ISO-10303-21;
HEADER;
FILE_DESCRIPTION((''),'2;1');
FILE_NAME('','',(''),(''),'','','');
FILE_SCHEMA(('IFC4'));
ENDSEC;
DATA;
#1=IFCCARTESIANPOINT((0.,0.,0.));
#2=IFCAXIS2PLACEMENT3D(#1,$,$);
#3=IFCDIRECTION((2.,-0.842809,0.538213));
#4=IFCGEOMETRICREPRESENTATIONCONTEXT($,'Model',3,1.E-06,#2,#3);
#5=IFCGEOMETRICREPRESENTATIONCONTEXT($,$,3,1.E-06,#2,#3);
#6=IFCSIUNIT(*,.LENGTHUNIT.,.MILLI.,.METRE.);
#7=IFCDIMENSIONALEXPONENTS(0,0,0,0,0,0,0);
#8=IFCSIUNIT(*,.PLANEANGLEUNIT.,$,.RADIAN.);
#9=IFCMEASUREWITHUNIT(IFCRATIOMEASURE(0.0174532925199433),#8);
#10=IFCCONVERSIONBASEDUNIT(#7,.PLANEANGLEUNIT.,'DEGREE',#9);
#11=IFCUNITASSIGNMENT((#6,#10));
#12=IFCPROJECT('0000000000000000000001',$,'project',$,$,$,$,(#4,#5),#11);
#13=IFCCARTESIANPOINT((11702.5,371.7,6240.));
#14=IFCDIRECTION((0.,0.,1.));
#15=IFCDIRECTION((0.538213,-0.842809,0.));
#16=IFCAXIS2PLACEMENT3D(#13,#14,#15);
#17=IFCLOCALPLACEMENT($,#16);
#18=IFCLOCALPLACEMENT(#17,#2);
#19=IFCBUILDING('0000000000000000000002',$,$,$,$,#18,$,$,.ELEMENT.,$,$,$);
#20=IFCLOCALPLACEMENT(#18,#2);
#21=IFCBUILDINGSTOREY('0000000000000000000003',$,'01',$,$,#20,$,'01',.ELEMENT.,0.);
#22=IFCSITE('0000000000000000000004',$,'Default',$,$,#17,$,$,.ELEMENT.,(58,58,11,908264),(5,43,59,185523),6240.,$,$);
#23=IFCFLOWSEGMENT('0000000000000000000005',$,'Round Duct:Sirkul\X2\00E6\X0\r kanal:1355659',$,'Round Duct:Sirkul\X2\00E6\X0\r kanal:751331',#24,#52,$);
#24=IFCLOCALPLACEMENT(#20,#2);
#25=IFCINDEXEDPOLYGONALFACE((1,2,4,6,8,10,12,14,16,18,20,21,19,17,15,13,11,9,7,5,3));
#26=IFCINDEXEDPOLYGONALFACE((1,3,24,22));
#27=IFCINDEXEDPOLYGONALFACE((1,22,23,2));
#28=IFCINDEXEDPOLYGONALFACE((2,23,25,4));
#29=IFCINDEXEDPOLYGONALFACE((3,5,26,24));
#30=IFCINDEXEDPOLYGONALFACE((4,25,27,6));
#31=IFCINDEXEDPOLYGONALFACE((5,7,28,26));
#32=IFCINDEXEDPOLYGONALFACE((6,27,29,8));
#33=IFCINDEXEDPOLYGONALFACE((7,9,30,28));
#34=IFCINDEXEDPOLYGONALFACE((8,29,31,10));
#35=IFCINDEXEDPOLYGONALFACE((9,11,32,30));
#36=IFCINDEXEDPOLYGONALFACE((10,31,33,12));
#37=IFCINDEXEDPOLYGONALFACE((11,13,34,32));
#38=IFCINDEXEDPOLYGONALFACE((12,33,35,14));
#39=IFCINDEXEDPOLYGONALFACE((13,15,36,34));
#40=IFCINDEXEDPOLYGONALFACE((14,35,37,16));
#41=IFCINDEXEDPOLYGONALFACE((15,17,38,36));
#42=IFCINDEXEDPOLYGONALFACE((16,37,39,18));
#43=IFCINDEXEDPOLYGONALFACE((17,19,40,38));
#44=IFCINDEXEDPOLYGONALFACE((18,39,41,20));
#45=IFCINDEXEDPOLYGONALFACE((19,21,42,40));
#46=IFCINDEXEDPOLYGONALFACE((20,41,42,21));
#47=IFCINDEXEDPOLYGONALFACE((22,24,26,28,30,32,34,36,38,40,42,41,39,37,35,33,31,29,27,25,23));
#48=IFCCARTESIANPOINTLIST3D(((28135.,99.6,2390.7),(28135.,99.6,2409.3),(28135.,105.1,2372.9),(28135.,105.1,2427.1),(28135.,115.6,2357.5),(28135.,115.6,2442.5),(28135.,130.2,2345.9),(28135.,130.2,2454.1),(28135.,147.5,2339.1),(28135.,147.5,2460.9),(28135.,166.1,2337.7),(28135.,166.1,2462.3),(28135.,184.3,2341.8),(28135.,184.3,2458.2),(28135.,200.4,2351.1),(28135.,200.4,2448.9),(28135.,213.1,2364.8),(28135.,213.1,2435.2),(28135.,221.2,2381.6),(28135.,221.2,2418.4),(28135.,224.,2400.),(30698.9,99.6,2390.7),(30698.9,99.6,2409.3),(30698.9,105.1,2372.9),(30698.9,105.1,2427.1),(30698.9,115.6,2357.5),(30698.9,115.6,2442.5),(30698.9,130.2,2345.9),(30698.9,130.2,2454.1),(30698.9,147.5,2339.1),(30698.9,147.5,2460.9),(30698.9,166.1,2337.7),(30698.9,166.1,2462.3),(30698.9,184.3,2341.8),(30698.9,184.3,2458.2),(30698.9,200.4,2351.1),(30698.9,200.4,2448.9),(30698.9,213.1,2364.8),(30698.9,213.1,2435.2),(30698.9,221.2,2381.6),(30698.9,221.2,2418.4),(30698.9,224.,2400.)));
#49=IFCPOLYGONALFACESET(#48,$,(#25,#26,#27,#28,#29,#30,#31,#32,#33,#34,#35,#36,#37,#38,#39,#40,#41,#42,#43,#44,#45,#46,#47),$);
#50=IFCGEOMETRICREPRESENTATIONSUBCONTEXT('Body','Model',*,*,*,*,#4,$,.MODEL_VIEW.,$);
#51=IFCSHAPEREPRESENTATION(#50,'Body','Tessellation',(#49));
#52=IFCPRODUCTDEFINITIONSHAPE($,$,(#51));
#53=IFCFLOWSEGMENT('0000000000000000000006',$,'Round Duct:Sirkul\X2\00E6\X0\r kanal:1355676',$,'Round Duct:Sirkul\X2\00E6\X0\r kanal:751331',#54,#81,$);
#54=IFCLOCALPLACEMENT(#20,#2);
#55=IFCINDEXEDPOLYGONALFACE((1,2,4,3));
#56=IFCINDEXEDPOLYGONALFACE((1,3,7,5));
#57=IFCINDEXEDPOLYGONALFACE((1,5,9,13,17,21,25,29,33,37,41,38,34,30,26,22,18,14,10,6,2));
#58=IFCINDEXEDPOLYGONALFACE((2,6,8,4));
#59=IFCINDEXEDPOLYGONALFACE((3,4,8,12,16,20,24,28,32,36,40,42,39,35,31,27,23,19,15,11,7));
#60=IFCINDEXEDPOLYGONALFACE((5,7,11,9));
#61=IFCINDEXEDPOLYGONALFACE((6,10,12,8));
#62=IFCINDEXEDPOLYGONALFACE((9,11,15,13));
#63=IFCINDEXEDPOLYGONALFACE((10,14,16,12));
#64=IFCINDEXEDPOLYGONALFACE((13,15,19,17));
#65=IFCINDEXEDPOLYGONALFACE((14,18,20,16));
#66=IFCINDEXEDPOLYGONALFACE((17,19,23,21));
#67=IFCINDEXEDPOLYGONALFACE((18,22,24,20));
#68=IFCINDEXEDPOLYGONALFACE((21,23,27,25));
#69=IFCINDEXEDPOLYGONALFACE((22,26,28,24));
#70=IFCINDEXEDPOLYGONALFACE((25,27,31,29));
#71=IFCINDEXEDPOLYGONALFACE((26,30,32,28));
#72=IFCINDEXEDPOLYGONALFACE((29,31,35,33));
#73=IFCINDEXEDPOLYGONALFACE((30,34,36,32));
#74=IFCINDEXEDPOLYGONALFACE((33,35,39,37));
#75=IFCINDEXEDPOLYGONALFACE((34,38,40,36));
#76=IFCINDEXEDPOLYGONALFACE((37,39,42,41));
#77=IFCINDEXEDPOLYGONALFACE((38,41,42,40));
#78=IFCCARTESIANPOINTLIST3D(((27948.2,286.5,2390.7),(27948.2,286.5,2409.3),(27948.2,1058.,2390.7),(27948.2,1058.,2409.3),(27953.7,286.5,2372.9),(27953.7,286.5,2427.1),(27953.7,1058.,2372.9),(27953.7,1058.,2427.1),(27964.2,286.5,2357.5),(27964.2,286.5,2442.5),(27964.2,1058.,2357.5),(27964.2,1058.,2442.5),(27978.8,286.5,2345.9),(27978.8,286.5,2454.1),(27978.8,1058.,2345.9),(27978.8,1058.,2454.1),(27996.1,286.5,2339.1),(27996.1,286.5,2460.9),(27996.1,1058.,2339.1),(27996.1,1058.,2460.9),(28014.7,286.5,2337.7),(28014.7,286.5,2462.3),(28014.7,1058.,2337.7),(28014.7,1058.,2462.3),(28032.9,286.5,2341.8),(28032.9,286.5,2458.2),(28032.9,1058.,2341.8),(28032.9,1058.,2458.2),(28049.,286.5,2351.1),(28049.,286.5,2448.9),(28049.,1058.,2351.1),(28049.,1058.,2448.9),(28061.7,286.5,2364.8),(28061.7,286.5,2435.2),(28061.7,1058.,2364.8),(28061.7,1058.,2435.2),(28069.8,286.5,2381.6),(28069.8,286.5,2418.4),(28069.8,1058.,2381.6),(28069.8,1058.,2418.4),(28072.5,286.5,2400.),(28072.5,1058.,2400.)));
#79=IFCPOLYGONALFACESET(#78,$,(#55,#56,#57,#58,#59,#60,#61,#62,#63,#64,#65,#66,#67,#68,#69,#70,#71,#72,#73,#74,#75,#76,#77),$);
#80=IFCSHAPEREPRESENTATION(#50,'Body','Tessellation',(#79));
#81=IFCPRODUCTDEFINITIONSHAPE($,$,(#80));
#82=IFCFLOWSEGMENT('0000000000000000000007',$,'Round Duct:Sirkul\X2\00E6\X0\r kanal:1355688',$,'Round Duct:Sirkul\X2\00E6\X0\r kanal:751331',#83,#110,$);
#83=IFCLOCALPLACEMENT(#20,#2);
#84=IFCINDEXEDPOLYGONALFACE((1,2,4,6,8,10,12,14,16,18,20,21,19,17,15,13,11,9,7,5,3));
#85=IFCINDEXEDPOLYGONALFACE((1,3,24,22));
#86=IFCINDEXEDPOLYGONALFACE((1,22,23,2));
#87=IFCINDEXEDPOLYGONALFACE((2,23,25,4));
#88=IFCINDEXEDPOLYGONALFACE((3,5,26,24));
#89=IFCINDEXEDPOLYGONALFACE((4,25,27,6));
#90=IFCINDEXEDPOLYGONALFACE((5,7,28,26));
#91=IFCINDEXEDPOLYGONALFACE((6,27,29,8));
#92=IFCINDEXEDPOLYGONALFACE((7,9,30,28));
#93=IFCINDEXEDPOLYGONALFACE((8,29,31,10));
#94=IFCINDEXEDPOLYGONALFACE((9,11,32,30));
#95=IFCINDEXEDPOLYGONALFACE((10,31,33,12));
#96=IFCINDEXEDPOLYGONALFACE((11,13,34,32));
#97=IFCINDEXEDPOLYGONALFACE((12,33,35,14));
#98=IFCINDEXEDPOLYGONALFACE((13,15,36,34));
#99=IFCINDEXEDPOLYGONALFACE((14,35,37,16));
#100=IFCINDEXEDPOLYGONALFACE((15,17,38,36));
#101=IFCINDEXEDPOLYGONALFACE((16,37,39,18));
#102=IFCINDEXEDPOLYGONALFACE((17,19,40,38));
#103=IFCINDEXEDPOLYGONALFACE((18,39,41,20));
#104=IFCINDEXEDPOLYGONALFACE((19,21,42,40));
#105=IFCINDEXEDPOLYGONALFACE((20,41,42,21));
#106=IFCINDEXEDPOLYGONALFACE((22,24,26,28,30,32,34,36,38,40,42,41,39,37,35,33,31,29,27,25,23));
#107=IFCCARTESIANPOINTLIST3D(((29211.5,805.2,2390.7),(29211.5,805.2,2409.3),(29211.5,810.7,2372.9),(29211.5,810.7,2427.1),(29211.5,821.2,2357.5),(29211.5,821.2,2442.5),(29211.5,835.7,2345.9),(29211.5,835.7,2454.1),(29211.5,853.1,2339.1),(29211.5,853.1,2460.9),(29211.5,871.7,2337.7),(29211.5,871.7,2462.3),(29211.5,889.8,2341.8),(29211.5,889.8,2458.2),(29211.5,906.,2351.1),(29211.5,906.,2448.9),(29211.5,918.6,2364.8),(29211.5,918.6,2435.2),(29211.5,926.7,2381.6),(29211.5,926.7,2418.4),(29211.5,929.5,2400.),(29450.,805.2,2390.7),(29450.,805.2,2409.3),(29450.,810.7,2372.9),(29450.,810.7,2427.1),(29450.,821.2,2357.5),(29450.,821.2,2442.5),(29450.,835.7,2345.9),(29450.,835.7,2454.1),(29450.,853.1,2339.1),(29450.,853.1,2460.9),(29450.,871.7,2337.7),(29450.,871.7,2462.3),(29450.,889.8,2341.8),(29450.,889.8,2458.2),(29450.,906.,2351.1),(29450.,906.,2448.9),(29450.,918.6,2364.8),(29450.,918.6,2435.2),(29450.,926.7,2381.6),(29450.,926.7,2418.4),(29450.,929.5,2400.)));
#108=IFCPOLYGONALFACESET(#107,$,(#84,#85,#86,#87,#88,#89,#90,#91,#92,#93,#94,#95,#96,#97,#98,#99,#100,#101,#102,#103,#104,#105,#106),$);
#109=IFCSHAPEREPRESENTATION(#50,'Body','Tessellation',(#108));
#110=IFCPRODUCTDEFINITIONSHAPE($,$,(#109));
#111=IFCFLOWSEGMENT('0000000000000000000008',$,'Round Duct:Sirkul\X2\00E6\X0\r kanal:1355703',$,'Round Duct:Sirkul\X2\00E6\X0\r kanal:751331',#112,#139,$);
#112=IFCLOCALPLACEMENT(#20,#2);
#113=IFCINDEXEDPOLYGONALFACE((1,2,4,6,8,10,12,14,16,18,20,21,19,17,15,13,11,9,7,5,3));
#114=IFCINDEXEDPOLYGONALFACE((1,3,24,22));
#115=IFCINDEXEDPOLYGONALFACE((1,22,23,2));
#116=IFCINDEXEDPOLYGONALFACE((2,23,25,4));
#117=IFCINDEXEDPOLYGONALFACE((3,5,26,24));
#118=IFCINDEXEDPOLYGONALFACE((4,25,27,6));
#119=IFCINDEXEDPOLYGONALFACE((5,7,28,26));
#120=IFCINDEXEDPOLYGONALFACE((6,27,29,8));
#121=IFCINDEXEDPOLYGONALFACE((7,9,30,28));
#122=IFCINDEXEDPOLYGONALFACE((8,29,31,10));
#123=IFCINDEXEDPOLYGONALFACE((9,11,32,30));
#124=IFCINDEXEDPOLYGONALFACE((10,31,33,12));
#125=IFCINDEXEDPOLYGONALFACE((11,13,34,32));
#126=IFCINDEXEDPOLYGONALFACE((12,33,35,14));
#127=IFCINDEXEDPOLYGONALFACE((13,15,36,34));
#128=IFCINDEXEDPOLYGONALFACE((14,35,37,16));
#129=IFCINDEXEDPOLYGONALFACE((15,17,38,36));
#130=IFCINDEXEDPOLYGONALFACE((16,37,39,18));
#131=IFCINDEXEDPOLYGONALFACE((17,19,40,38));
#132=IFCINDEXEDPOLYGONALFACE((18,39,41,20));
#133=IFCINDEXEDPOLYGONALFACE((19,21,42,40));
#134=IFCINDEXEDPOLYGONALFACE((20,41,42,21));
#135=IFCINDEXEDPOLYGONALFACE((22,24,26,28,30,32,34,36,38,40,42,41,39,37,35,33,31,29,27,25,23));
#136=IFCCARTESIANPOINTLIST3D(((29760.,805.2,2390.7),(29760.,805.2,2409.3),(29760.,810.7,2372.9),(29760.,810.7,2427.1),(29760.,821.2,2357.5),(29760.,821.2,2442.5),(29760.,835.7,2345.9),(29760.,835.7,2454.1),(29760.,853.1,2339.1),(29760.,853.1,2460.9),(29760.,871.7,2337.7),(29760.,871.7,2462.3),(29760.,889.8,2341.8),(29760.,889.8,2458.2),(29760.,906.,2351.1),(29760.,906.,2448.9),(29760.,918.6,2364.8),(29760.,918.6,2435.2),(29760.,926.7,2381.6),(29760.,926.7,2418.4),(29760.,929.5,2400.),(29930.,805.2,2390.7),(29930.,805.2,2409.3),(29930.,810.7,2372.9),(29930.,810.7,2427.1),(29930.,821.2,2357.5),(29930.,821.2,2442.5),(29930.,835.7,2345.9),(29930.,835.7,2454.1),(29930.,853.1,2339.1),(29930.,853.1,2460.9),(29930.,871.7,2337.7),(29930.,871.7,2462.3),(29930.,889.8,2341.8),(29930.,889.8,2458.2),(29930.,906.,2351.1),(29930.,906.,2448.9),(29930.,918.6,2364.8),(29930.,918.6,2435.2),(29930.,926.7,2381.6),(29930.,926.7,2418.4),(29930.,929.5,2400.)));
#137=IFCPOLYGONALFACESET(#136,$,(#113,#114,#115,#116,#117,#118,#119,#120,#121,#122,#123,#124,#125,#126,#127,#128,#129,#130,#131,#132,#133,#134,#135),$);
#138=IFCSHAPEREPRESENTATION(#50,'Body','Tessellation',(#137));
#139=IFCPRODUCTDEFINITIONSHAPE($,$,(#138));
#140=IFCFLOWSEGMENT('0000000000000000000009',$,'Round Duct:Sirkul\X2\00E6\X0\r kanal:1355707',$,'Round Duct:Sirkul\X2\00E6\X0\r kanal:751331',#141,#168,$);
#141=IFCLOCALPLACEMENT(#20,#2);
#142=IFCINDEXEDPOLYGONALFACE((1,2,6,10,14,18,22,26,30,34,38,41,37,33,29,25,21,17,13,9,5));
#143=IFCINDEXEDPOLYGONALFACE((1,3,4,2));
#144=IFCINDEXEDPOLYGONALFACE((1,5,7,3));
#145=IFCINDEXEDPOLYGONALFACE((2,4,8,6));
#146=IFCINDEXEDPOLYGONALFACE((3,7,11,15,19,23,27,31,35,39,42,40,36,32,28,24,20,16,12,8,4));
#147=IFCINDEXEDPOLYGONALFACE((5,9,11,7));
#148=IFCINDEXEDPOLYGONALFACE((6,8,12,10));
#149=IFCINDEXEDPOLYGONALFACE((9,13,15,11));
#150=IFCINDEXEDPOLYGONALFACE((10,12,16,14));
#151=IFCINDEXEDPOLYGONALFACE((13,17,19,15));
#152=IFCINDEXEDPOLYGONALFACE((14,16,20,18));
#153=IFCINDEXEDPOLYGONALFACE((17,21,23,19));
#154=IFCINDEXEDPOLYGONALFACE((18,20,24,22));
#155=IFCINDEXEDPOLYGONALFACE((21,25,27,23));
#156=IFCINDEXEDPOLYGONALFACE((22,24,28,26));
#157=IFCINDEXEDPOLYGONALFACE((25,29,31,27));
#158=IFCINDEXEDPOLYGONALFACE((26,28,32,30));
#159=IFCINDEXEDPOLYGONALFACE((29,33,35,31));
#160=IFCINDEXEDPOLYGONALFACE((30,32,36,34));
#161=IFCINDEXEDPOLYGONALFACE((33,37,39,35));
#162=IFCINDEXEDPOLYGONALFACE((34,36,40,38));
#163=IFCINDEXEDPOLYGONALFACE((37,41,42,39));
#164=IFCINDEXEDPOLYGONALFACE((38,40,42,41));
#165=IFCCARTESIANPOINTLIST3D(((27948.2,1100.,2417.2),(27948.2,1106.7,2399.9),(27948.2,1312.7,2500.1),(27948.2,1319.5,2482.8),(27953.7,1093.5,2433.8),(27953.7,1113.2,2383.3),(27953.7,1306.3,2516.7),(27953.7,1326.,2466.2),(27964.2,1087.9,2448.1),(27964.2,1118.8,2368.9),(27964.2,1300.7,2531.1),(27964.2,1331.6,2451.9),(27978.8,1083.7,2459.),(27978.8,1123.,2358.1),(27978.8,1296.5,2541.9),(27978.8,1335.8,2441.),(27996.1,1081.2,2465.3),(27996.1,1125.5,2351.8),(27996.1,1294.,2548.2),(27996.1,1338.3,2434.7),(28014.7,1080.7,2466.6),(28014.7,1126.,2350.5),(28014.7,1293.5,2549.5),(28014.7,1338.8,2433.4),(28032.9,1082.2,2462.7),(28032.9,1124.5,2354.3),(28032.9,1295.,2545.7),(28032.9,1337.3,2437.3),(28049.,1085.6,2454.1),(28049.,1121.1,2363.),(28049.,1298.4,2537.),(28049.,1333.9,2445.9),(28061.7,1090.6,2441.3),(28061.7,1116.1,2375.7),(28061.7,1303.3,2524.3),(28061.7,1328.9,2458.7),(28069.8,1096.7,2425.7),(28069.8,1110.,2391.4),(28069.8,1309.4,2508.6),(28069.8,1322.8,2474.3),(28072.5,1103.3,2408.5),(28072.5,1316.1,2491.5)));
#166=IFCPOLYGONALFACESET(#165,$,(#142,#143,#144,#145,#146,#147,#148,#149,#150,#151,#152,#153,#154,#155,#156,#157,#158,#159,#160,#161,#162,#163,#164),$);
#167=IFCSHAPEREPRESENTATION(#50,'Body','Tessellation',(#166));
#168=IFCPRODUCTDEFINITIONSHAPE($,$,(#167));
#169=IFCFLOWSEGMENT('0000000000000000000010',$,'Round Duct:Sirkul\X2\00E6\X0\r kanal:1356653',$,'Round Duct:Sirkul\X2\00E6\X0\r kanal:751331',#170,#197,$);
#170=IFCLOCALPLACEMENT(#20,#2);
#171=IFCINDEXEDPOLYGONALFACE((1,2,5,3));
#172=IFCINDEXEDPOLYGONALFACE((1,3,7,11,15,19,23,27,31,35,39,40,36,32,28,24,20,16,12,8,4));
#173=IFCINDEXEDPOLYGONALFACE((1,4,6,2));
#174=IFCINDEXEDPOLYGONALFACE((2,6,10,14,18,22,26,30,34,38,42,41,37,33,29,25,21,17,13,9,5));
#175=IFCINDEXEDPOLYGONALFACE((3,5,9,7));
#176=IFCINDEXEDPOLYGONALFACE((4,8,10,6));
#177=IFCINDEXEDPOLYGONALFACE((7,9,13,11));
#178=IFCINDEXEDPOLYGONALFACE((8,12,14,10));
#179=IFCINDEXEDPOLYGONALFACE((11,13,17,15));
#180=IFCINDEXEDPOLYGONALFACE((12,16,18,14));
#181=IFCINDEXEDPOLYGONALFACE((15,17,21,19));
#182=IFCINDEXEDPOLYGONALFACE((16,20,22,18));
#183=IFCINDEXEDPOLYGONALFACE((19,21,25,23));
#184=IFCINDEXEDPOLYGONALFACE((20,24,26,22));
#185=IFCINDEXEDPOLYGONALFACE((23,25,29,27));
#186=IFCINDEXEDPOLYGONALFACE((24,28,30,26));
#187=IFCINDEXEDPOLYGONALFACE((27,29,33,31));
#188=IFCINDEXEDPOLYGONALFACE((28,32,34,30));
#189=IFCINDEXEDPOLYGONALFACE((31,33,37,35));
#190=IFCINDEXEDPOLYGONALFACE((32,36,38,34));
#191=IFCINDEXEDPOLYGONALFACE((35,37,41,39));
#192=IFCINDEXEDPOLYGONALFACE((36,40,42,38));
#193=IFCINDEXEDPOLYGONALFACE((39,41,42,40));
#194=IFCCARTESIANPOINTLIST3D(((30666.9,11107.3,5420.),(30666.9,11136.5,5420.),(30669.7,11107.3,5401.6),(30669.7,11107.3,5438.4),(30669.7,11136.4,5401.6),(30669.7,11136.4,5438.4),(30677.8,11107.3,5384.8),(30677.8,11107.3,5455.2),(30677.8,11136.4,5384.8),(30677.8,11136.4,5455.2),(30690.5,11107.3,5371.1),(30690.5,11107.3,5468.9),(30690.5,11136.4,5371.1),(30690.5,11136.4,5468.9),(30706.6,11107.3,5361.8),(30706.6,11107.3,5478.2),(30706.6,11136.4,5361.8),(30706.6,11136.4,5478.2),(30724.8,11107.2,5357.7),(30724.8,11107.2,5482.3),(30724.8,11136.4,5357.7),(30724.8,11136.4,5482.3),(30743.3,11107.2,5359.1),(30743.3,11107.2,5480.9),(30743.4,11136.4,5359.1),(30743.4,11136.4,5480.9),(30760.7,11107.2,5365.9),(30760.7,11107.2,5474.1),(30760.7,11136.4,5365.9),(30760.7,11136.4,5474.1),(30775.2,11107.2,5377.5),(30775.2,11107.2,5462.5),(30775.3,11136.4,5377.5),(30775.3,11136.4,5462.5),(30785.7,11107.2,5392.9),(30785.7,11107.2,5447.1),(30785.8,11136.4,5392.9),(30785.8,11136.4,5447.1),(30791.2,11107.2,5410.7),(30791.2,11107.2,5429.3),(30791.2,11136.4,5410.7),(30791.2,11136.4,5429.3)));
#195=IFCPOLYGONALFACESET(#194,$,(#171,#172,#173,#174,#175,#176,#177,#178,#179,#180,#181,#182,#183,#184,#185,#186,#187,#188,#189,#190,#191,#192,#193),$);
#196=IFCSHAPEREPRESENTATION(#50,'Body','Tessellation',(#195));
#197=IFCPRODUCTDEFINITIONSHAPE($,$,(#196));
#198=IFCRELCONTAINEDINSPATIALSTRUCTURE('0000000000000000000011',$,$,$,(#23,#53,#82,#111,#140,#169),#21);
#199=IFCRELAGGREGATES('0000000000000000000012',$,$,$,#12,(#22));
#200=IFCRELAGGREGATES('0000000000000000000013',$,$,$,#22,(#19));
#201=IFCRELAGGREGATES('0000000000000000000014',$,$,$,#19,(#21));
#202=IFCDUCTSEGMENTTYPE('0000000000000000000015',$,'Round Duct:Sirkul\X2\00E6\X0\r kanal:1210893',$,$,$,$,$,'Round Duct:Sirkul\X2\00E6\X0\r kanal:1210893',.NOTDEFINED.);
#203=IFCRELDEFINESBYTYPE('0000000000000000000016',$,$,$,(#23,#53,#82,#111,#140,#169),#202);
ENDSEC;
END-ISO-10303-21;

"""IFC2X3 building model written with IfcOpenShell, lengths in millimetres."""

from ifc_helpers import new_model, entity, si_unit, converted_unit, direction, frame, frame_2d, origin, origin_2d_with_axis, place, context, subcontext, project, spatial, circle, extrude, type_object, element, save


model = new_model("IFC2X3")

# Units and contexts
model_context = context("Model", 3, precision=1e-06, world=origin(), true_north=direction((2.0, -0.842809, 0.538213)))
context_of_model = context(None, 3, precision=1e-06, world=origin(), true_north=direction((2.0, -0.842809, 0.538213)))
body_context = subcontext(model_context, "Body", "Model", "MODEL_VIEW")
ifc_project = project(units=[si_unit("LENGTHUNIT", "METRE", prefix="MILLI"), converted_unit("PLANEANGLEUNIT", "DEGREE", entity("IfcRatioMeasure", 0.0174532925199433), si_unit("PLANEANGLEUNIT", "RADIAN"), dimensions=[0, 0, 0, 0, 0, 0, 0])], contexts=[model_context, context_of_model])

# Site, building, storey
site_placement = place(None, frame((11702.5, 371.7, 6240.0), z_axis=(0.0, 0.0, 1.0), x_axis=(0.538213, -0.842809, 0.0)))
site = spatial("IfcSite", under=ifc_project, at=site_placement, Name="Default", CompositionType="ELEMENT", RefLatitude=(58, 58, 11, 908264), RefLongitude=(5, 43, 59, 185523), RefElevation=6240.0)
building_placement = place(site_placement, origin())
building = spatial("IfcBuilding", under=site, at=building_placement, CompositionType="ELEMENT")
storey_placement = place(building_placement, origin())
storey = spatial("IfcBuildingStorey", under=building, at=storey_placement, Name="01", LongName="01", CompositionType="ELEMENT", Elevation=0.0)

# Flow segments
duct_segment_type = type_object("IfcDuctSegmentType", Name="Round Duct:Sirkulær kanal:1210893", ElementType="Round Duct:Sirkulær kanal:1210893", PredefinedType="NOTDEFINED")
flow_segment_1_placement = place(storey_placement, origin())
element("IfcFlowSegment", 1, at=flow_segment_1_placement, inside=storey, type_object=duct_segment_type, Name="Round Duct:Sirkulær kanal:1355659", ObjectType="Round Duct:Sirkulær kanal:751331", context=body_context, shape_type="SweptSolid", body=[
    extrude(circle(Radius=62.5, at=frame_2d((0.0, 0.0), x_axis=(1.0, 0.0))), frame((28135.0, 161.5, 2400.0), z_axis=(1.0, 0.0, 0.0), x_axis=(0.0, 1.0, 0.0)), (0.0, 0.0, 1.0), 2563.8),
])
flow_segment_2_placement = place(storey_placement, origin())
element("IfcFlowSegment", 2, at=flow_segment_2_placement, inside=storey, type_object=duct_segment_type, Name="Round Duct:Sirkulær kanal:1355676", ObjectType="Round Duct:Sirkulær kanal:751331", context=body_context, shape_type="SweptSolid", body=[
    extrude(circle(Radius=62.5, at=origin_2d_with_axis()), frame((28010.0, 286.5, 2400.0), z_axis=(0.0, 1.0, 0.0), x_axis=(1.0, 0.0, 0.0)), (0.0, 0.0, 1.0), 771.5),
])
flow_segment_3_placement = place(storey_placement, origin())
element("IfcFlowSegment", 3, at=flow_segment_3_placement, inside=storey, type_object=duct_segment_type, Name="Round Duct:Sirkulær kanal:1355688", ObjectType="Round Duct:Sirkulær kanal:751331", context=body_context, shape_type="SweptSolid", body=[
    extrude(circle(Radius=62.5, at=frame_2d((0.0, 0.0), x_axis=(1.0, 0.0))), frame((29211.5, 867.0, 2400.0), z_axis=(1.0, 0.0, 0.0), x_axis=(0.0, 1.0, 0.0)), (0.0, 0.0, 1.0), 238.5),
])
flow_segment_4_placement = place(storey_placement, origin())
element("IfcFlowSegment", 4, at=flow_segment_4_placement, inside=storey, type_object=duct_segment_type, Name="Round Duct:Sirkulær kanal:1355703", ObjectType="Round Duct:Sirkulær kanal:751331", context=body_context, shape_type="SweptSolid", body=[
    extrude(circle(Radius=62.5, at=frame_2d((0.0, 0.0), x_axis=(1.0, 0.0))), frame((29760.0, 867.0, 2400.0), z_axis=(1.0, 0.0, 0.0), x_axis=(0.0, 1.0, 0.0)), (0.0, 0.0, 1.0), 170.0),
])
flow_segment_5_placement = place(storey_placement, origin())
element("IfcFlowSegment", 5, at=flow_segment_5_placement, inside=storey, type_object=duct_segment_type, Name="Round Duct:Sirkulær kanal:1355707", ObjectType="Round Duct:Sirkulær kanal:751331", context=body_context, shape_type="SweptSolid", body=[
    extrude(circle(Radius=62.5, at=origin_2d_with_axis()), frame((28010.0, 1103.3, 2408.5), z_axis=(0.0, 0.931734, 0.363142), x_axis=(1.0, 0.0, 0.0)), (0.0, 0.0, 1.0), 228.4),
])
flow_segment_6_placement = place(storey_placement, origin())
element("IfcFlowSegment", 6, at=flow_segment_6_placement, inside=storey, type_object=duct_segment_type, Name="Round Duct:Sirkulær kanal:1356653", ObjectType="Round Duct:Sirkulær kanal:751331", context=body_context, shape_type="SweptSolid", body=[
    extrude(circle(Radius=62.5, at=frame_2d((0.0, 0.0), x_axis=(1.0, 0.0))), frame((30729.4, 11107.2, 5420.0), z_axis=(0.000629, 1.0, 0.0), x_axis=(-1.0, 0.000629, 0.0)), (0.0, 0.0, 1.0), 29.2),
])

save(model, "model.ifc")
